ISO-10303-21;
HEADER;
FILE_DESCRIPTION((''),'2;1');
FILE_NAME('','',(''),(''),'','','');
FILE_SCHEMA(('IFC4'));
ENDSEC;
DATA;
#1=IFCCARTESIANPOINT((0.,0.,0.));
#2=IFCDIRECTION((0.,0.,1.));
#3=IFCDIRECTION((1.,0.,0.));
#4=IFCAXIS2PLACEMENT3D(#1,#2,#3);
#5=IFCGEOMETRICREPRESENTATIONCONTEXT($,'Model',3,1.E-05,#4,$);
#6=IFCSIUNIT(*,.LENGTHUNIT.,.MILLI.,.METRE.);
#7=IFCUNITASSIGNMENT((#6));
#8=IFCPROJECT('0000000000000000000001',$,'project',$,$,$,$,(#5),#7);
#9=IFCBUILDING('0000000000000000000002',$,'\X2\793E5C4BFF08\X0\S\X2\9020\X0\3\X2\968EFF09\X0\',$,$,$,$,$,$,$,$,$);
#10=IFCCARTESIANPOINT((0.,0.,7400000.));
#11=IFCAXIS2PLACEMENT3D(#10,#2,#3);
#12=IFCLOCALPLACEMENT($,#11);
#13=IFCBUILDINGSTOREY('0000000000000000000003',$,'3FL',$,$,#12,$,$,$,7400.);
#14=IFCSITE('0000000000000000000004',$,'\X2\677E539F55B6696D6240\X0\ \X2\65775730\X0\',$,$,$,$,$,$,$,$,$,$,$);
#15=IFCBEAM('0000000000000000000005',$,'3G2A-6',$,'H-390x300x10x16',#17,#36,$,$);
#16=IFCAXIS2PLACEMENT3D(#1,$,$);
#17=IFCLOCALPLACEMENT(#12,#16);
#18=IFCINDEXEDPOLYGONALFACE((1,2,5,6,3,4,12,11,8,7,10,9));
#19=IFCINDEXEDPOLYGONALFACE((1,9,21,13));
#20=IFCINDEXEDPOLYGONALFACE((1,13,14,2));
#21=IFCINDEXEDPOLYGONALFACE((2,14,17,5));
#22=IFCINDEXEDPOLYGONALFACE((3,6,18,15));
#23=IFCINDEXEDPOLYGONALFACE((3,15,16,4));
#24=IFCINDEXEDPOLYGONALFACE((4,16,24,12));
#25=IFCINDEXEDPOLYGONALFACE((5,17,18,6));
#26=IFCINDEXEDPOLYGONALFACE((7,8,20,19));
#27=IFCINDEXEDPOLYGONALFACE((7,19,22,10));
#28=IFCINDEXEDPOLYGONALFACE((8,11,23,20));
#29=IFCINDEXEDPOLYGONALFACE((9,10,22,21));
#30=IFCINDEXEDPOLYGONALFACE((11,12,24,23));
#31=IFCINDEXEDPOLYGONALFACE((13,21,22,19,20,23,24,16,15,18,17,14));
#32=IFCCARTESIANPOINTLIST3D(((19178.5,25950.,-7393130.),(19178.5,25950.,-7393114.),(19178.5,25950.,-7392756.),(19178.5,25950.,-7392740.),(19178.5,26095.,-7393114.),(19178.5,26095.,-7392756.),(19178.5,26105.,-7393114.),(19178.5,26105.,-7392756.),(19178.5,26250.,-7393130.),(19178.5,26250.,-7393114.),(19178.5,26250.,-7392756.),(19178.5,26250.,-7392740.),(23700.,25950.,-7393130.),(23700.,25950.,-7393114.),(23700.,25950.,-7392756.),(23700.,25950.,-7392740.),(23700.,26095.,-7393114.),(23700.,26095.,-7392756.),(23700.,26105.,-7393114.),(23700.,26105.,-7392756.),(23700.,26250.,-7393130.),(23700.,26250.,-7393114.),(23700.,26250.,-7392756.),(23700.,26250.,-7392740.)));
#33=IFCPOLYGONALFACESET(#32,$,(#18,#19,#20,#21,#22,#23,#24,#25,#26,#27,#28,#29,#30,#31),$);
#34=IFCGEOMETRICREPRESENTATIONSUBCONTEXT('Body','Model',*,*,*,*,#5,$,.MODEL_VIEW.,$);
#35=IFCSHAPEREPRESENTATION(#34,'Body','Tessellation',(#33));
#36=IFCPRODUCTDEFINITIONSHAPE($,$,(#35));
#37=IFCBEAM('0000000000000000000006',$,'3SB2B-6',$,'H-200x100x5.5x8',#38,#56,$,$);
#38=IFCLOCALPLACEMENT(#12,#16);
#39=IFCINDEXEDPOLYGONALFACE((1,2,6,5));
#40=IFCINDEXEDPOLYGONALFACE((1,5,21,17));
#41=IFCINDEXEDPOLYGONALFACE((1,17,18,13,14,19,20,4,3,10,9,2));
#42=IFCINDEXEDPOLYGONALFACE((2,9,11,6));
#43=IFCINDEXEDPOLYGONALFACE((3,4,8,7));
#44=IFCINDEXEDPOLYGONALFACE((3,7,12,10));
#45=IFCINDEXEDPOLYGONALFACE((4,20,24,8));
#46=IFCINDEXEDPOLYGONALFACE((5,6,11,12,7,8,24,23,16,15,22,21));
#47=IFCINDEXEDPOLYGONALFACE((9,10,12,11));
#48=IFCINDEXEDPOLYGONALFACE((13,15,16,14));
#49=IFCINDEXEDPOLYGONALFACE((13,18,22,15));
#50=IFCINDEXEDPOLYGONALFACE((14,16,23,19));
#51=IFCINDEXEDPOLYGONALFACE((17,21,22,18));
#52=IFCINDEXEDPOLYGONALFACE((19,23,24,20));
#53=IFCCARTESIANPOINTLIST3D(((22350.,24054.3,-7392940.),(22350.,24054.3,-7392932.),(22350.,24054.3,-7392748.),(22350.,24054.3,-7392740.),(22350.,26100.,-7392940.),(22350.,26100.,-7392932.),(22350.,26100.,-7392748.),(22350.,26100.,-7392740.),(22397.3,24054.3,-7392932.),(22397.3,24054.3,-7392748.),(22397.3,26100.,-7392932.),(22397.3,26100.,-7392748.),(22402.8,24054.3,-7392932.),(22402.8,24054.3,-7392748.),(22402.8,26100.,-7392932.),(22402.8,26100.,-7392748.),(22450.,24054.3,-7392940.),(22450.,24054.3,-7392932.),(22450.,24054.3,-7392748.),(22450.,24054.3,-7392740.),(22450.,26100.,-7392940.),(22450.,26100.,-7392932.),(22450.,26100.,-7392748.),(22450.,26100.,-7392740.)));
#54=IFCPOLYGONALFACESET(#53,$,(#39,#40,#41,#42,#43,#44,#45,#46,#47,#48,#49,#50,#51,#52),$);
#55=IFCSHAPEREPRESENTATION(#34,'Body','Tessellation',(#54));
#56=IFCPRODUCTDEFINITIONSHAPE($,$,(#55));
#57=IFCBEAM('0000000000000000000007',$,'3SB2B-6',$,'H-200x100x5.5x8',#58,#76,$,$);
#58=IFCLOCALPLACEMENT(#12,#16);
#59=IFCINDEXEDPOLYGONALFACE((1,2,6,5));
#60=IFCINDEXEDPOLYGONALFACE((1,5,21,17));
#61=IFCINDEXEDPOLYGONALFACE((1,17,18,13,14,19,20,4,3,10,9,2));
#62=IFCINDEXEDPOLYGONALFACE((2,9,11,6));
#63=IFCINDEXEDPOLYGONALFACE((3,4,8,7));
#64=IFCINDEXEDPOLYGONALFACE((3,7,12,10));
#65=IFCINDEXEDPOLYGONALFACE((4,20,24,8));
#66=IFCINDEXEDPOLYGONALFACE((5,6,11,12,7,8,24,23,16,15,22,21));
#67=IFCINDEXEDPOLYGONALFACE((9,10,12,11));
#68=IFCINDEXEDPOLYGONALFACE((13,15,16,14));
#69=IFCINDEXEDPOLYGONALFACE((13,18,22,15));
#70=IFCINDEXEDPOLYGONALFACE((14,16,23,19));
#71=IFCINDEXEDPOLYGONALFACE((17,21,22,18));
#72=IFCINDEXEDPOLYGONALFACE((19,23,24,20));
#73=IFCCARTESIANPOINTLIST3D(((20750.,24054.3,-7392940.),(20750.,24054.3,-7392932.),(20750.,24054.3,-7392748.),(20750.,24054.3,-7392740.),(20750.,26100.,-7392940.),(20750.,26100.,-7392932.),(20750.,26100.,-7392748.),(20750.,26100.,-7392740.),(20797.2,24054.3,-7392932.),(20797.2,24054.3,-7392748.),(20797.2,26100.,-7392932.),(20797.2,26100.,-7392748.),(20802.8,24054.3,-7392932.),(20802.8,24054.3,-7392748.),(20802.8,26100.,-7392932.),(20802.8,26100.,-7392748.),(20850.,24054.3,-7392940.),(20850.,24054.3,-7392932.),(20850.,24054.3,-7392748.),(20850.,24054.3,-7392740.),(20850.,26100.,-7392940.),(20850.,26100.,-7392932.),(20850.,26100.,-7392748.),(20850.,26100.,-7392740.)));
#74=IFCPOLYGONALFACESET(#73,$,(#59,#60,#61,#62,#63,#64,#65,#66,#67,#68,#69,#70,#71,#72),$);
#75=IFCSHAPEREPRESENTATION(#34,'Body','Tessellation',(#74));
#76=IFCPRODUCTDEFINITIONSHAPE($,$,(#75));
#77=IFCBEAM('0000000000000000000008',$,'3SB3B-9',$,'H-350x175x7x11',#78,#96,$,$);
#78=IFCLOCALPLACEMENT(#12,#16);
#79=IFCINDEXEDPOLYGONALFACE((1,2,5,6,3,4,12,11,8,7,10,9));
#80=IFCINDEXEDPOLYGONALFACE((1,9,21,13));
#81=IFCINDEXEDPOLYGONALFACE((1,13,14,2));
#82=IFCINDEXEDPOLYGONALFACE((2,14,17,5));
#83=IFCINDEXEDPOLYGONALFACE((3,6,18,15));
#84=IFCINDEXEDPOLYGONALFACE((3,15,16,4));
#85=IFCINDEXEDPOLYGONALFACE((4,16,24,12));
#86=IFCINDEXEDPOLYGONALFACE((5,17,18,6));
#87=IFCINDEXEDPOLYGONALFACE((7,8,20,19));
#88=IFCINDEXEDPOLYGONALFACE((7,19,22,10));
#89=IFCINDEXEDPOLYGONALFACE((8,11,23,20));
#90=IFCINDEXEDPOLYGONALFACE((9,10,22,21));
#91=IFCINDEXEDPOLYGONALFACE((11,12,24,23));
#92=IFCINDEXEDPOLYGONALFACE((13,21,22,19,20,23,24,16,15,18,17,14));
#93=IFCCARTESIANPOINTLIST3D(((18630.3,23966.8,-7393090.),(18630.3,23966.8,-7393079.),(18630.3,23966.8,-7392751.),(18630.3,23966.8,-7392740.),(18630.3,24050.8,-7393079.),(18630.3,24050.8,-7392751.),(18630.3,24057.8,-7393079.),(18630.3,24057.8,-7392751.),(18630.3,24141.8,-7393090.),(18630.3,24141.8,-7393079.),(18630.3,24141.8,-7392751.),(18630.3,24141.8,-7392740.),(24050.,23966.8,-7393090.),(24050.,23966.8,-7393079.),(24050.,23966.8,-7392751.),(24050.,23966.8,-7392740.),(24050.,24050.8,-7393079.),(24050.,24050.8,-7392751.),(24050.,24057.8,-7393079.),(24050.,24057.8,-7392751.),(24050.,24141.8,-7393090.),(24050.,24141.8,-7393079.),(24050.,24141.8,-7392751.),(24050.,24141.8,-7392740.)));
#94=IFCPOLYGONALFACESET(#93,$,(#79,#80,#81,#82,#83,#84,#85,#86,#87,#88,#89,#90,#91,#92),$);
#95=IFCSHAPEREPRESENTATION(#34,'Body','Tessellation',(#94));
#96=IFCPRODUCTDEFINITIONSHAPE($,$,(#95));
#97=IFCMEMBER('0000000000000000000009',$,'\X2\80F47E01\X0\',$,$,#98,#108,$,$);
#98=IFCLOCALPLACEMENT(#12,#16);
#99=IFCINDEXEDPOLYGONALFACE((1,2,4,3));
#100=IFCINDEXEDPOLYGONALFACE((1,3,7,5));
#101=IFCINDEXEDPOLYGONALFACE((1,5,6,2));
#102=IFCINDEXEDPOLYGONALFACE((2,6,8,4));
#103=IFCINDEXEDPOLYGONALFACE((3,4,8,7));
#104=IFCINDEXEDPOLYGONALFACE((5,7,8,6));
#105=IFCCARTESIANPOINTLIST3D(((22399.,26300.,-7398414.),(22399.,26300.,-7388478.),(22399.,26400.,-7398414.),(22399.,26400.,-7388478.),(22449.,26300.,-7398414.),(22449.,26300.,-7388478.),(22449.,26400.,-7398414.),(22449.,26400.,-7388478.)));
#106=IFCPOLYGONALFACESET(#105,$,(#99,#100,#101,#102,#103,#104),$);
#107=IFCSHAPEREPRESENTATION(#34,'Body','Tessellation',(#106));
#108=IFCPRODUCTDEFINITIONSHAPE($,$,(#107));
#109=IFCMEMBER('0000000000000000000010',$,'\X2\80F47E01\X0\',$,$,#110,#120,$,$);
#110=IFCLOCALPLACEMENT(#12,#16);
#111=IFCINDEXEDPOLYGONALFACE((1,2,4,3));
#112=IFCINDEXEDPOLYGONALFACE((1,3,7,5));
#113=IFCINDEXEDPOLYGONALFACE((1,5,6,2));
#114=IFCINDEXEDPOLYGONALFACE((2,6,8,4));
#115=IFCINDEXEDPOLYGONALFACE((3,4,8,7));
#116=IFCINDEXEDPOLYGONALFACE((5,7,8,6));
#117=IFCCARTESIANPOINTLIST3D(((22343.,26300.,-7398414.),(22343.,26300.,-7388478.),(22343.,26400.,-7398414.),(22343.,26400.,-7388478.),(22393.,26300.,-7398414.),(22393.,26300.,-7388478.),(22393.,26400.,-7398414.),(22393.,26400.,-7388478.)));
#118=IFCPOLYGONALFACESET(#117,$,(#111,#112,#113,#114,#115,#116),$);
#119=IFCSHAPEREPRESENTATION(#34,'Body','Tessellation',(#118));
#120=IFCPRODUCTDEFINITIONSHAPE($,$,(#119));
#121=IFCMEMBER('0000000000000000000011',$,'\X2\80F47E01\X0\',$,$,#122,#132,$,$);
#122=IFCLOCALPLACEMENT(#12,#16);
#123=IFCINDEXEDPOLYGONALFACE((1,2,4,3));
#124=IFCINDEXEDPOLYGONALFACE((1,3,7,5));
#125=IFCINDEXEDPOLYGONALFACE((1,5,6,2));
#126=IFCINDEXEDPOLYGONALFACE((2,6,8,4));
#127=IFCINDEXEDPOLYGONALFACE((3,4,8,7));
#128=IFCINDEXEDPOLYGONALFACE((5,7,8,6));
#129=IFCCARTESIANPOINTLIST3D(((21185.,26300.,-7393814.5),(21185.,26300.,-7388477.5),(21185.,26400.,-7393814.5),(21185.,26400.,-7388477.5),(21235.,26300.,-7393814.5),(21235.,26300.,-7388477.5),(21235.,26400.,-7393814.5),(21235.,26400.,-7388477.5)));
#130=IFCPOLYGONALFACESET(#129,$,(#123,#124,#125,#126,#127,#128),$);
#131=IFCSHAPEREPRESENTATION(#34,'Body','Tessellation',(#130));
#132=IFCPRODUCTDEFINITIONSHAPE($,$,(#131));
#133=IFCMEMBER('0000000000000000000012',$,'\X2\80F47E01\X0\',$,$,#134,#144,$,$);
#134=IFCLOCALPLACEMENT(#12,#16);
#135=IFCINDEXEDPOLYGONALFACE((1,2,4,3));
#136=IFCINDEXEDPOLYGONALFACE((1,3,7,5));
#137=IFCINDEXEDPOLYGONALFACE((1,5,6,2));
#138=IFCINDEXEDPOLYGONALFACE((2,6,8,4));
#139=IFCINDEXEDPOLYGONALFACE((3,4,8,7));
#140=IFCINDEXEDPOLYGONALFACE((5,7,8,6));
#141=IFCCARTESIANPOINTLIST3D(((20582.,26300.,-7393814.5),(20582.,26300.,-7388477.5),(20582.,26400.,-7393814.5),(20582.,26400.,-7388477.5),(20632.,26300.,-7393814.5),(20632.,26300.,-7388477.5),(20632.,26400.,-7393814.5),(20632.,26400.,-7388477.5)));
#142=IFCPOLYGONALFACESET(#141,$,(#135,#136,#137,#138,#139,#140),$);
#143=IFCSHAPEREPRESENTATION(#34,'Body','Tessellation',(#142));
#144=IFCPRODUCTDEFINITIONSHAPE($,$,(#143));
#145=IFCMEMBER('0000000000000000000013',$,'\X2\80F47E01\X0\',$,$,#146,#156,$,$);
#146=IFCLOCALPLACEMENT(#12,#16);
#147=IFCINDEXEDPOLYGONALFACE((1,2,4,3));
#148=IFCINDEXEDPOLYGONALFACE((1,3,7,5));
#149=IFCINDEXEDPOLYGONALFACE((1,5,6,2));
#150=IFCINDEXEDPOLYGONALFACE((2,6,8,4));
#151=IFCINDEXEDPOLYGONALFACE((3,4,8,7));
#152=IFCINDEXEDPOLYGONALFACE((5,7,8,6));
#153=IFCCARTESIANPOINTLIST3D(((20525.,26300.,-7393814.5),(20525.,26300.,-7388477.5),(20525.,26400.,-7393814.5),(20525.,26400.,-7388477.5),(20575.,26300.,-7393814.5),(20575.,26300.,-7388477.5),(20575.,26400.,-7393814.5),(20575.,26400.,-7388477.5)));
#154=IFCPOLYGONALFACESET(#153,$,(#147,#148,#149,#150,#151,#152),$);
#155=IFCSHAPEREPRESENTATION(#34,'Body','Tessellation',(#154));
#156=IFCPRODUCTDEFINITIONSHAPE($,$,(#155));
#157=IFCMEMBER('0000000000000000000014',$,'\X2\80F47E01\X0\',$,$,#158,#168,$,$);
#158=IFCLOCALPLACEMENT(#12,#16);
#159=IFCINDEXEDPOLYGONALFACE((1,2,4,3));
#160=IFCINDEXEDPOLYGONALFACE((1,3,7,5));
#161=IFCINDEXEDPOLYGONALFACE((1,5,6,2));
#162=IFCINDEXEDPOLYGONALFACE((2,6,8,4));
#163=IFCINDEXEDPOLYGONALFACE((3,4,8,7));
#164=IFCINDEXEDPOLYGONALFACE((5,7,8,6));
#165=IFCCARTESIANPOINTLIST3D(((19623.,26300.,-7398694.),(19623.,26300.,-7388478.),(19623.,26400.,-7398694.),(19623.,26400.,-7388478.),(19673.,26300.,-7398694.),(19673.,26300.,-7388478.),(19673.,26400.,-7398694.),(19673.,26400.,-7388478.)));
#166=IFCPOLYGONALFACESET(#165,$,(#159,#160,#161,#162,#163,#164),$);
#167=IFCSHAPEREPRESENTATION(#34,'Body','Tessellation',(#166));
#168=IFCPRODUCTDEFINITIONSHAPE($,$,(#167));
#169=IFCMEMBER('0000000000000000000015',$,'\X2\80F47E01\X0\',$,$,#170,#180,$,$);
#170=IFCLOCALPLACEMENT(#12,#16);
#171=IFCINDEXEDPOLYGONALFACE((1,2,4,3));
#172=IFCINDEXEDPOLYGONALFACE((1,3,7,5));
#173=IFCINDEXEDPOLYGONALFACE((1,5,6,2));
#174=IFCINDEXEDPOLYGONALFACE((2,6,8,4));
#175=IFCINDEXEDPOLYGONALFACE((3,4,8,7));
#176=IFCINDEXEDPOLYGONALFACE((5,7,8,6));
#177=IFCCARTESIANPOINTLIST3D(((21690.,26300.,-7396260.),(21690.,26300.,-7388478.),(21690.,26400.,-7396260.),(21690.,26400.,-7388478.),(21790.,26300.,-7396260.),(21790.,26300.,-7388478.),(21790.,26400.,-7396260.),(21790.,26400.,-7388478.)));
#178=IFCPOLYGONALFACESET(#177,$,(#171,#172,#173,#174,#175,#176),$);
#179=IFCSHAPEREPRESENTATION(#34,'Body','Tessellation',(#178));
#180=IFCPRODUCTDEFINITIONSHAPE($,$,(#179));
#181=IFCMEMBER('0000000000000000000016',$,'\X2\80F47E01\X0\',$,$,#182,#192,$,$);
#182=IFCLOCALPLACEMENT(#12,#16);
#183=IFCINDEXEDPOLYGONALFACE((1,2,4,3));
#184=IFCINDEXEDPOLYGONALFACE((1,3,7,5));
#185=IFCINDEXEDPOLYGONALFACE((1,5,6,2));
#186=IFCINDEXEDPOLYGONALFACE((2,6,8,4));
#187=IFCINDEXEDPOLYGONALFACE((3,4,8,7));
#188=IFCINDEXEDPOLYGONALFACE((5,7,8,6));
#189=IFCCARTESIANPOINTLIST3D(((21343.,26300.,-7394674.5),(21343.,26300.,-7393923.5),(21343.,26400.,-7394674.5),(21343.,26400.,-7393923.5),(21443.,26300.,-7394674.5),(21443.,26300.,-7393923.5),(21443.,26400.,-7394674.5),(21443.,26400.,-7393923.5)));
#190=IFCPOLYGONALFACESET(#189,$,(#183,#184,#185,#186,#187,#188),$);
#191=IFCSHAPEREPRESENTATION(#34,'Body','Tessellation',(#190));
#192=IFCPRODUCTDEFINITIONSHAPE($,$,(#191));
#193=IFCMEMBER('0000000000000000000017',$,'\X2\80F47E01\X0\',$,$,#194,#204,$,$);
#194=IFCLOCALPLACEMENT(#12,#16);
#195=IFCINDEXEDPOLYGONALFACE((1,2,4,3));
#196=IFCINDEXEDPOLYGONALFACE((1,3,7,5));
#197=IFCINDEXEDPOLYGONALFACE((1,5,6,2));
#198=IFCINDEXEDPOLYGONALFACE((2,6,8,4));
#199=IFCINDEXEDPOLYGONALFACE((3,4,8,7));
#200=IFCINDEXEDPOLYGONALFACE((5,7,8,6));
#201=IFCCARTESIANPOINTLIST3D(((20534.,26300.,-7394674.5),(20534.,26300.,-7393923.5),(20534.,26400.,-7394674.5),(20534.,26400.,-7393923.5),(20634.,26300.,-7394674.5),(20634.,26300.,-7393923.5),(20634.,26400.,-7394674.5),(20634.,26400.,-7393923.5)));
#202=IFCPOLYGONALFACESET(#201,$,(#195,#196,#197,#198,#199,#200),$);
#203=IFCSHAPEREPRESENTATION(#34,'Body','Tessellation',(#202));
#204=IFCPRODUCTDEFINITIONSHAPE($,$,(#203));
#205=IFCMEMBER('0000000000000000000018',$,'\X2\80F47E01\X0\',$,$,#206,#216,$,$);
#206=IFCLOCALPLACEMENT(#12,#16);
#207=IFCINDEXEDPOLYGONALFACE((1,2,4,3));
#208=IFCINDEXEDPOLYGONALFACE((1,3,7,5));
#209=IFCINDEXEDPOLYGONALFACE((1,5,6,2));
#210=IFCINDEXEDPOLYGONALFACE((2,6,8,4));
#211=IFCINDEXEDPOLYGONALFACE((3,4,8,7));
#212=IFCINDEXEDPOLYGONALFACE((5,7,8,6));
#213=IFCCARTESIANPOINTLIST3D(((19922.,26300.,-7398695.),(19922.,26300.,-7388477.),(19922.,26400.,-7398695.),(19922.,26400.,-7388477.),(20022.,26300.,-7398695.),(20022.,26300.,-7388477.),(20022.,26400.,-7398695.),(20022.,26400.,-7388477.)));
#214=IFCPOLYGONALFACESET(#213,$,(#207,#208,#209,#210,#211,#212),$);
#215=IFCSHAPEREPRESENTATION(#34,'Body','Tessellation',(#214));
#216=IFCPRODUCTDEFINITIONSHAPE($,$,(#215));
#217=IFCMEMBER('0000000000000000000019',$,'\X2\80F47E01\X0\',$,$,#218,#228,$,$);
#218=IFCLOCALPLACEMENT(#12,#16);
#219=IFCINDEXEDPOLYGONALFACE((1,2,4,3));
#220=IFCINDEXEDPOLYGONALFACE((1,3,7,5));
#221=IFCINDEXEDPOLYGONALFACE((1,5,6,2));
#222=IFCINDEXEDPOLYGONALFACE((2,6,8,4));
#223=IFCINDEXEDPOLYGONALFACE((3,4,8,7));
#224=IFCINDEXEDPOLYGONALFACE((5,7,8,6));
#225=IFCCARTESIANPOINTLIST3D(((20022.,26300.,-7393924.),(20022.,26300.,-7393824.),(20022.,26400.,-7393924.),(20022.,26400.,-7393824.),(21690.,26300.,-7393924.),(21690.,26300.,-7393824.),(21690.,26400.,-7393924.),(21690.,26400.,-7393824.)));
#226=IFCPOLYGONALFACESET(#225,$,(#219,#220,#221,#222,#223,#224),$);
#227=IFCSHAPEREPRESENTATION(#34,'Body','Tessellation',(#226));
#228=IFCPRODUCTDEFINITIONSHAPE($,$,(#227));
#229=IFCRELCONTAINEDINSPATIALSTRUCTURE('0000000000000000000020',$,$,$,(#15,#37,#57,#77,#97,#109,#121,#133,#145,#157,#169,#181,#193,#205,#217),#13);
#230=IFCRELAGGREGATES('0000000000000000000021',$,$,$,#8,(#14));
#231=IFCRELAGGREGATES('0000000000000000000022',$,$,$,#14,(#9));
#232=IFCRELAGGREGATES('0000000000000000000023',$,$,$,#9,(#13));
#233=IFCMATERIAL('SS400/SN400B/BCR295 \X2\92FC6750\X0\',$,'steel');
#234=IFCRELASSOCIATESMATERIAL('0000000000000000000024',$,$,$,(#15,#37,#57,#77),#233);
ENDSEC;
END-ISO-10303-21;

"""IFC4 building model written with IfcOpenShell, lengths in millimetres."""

from ifc_helpers import new_model, si_unit, frame, origin, origin_with_axes, place, context, subcontext, project, spatial, rectangle, i_section, extrude, material, element, save


model = new_model("IFC4")

# Units and contexts
model_context = context("Model", 3, precision=1e-05, world=origin_with_axes())
body_context = subcontext(model_context, "Body", "Model", "MODEL_VIEW")
ifc_project = project(units=[si_unit("LENGTHUNIT", "METRE", prefix="MILLI")], contexts=[model_context])

# Site, building, storey
site = spatial("IfcSite", under=ifc_project, Name="松原営業所 敷地")
building = spatial("IfcBuilding", under=site, Name="社屋（S造3階）")
storey_placement = place(None, frame((0.0, 0.0, 7400000.0), z_axis=(0.0, 0.0, 1.0), x_axis=(1.0, 0.0, 0.0)))
storey = spatial("IfcBuildingStorey", under=building, at=storey_placement, Name="3FL", Elevation=7400.0)

# Beams
ifc_material = material(Name="SS400/SN400B/BCR295 鋼材", Category="steel")
beam_1_placement = place(storey_placement, frame((19178.5, 26100.0, -7392740.0), z_axis=(1.0, 0.0, 0.0), x_axis=(0.0, 1.0, 0.0)))
element("IfcBeam", 1, at=beam_1_placement, inside=storey, material=ifc_material, Name="3G2A-6", ObjectType="H-390x300x10x16", context=body_context, shape_type="SweptSolid", body=[
    extrude(i_section(OverallWidth=300.0, OverallDepth=390.0, WebThickness=10.0, FlangeThickness=16.0), frame((0.0, -195.0, 0.0)), (0.0, 0.0, 1.0), 4521.5),
])
for number, where, z_axis, x_axis, name in (
    (2, (22400.0, 24054.3, -7392740.0), (0.0, 1.0, 0.0), (-1.0, 0.0, 0.0), "3SB2B-6"),
    (3, (20800.0, 24054.3, -7392740.0), (0.0, 1.0, 0.0), (-1.0, 0.0, 0.0), "3SB2B-6"),
):
    element("IfcBeam", number, at=place(storey_placement, frame(where, z_axis=z_axis, x_axis=x_axis)), inside=storey, material=ifc_material, Name=name, ObjectType="H-200x100x5.5x8", context=body_context, shape_type="SweptSolid", body=[
        extrude(i_section(OverallWidth=100.0, OverallDepth=200.0, WebThickness=5.5, FlangeThickness=8.0), frame((0.0, -100.0, 0.0)), (0.0, 0.0, 1.0), 2045.7),
    ])
beam_2_placement = place(storey_placement, frame((18630.3, 24054.3, -7392740.0), z_axis=(1.0, 0.0, 0.0), x_axis=(0.0, 1.0, 0.0)))
element("IfcBeam", 4, at=beam_2_placement, inside=storey, material=ifc_material, Name="3SB3B-9", ObjectType="H-350x175x7x11", context=body_context, shape_type="SweptSolid", body=[
    extrude(i_section(OverallWidth=175.0, OverallDepth=350.0, WebThickness=7.0, FlangeThickness=11.0), frame((0.0, -175.0, 0.0)), (0.0, 0.0, 1.0), 5419.7),
])

# Members
for number, where, z_axis, x_axis, name in (
    (5, (22449.0, 26350.0, -7393446.0), (-1.0, 0.0, 0.0), (0.0, -1.0, 0.0), "胴縁"),
    (6, (22393.0, 26350.0, -7393446.0), (-1.0, 0.0, 0.0), (0.0, -1.0, 0.0), "胴縁"),
):
    element("IfcMember", number, at=place(storey_placement, frame(where, z_axis=z_axis, x_axis=x_axis)), inside=storey, Name=name, context=body_context, shape_type="SweptSolid", body=[
        extrude(rectangle(XDim=100.0, YDim=9936.0), origin(), (0.0, 0.0, 1.0), 50.0),
    ])
for number, where, z_axis, x_axis, name in (
    (7, (21235.0, 26350.0, -7391146.0), (-1.0, 0.0, 0.0), (0.0, -1.0, 0.0), "胴縁"),
    (8, (20632.0, 26350.0, -7391146.0), (-1.0, 0.0, 0.0), (0.0, -1.0, 0.0), "胴縁"),
    (9, (20575.0, 26350.0, -7391146.0), (-1.0, 0.0, 0.0), (0.0, -1.0, 0.0), "胴縁"),
):
    element("IfcMember", number, at=place(storey_placement, frame(where, z_axis=z_axis, x_axis=x_axis)), inside=storey, Name=name, context=body_context, shape_type="SweptSolid", body=[
        extrude(rectangle(XDim=100.0, YDim=5337.0), origin(), (0.0, 0.0, 1.0), 50.0),
    ])
member_1_placement = place(storey_placement, frame((19673.0, 26350.0, -7393586.0), z_axis=(-1.0, 0.0, 0.0), x_axis=(0.0, -1.0, 0.0)))
element("IfcMember", 10, at=member_1_placement, inside=storey, Name="胴縁", context=body_context, shape_type="SweptSolid", body=[
    extrude(rectangle(XDim=100.0, YDim=10216.0), origin(), (0.0, 0.0, 1.0), 50.0),
])
member_2_placement = place(storey_placement, frame((21790.0, 26350.0, -7392369.0), z_axis=(-1.0, 0.0, 0.0), x_axis=(0.0, -1.0, 0.0)))
element("IfcMember", 11, at=member_2_placement, inside=storey, Name="胴縁", context=body_context, shape_type="SweptSolid", body=[
    extrude(rectangle(XDim=100.0, YDim=7782.0), origin(), (0.0, 0.0, 1.0), 100.0),
])
for number, where, z_axis, x_axis, name in (
    (12, (21443.0, 26350.0, -7394299.0), (-1.0, 0.0, 0.0), (0.0, -1.0, 0.0), "胴縁"),
    (13, (20634.0, 26350.0, -7394299.0), (-1.0, 0.0, 0.0), (0.0, -1.0, 0.0), "胴縁"),
):
    element("IfcMember", number, at=place(storey_placement, frame(where, z_axis=z_axis, x_axis=x_axis)), inside=storey, Name=name, context=body_context, shape_type="SweptSolid", body=[
        extrude(rectangle(XDim=100.0, YDim=751.0), origin(), (0.0, 0.0, 1.0), 100.0),
    ])
member_3_placement = place(storey_placement, frame((20022.0, 26350.0, -7393586.0), z_axis=(-1.0, 0.0, 0.0), x_axis=(0.0, -1.0, 0.0)))
element("IfcMember", 14, at=member_3_placement, inside=storey, Name="胴縁", context=body_context, shape_type="SweptSolid", body=[
    extrude(rectangle(XDim=100.0, YDim=10218.0), origin(), (0.0, 0.0, 1.0), 100.0),
])
member_4_placement = place(storey_placement, frame((21690.0, 26350.0, -7393874.0), z_axis=(-1.0, 0.0, 0.0), x_axis=(0.0, -1.0, 0.0)))
element("IfcMember", 15, at=member_4_placement, inside=storey, Name="胴縁", context=body_context, shape_type="SweptSolid", body=[
    extrude(rectangle(XDim=100.0, YDim=100.0), origin(), (0.0, 0.0, 1.0), 1668.0),
])

save(model, "model.ifc")
